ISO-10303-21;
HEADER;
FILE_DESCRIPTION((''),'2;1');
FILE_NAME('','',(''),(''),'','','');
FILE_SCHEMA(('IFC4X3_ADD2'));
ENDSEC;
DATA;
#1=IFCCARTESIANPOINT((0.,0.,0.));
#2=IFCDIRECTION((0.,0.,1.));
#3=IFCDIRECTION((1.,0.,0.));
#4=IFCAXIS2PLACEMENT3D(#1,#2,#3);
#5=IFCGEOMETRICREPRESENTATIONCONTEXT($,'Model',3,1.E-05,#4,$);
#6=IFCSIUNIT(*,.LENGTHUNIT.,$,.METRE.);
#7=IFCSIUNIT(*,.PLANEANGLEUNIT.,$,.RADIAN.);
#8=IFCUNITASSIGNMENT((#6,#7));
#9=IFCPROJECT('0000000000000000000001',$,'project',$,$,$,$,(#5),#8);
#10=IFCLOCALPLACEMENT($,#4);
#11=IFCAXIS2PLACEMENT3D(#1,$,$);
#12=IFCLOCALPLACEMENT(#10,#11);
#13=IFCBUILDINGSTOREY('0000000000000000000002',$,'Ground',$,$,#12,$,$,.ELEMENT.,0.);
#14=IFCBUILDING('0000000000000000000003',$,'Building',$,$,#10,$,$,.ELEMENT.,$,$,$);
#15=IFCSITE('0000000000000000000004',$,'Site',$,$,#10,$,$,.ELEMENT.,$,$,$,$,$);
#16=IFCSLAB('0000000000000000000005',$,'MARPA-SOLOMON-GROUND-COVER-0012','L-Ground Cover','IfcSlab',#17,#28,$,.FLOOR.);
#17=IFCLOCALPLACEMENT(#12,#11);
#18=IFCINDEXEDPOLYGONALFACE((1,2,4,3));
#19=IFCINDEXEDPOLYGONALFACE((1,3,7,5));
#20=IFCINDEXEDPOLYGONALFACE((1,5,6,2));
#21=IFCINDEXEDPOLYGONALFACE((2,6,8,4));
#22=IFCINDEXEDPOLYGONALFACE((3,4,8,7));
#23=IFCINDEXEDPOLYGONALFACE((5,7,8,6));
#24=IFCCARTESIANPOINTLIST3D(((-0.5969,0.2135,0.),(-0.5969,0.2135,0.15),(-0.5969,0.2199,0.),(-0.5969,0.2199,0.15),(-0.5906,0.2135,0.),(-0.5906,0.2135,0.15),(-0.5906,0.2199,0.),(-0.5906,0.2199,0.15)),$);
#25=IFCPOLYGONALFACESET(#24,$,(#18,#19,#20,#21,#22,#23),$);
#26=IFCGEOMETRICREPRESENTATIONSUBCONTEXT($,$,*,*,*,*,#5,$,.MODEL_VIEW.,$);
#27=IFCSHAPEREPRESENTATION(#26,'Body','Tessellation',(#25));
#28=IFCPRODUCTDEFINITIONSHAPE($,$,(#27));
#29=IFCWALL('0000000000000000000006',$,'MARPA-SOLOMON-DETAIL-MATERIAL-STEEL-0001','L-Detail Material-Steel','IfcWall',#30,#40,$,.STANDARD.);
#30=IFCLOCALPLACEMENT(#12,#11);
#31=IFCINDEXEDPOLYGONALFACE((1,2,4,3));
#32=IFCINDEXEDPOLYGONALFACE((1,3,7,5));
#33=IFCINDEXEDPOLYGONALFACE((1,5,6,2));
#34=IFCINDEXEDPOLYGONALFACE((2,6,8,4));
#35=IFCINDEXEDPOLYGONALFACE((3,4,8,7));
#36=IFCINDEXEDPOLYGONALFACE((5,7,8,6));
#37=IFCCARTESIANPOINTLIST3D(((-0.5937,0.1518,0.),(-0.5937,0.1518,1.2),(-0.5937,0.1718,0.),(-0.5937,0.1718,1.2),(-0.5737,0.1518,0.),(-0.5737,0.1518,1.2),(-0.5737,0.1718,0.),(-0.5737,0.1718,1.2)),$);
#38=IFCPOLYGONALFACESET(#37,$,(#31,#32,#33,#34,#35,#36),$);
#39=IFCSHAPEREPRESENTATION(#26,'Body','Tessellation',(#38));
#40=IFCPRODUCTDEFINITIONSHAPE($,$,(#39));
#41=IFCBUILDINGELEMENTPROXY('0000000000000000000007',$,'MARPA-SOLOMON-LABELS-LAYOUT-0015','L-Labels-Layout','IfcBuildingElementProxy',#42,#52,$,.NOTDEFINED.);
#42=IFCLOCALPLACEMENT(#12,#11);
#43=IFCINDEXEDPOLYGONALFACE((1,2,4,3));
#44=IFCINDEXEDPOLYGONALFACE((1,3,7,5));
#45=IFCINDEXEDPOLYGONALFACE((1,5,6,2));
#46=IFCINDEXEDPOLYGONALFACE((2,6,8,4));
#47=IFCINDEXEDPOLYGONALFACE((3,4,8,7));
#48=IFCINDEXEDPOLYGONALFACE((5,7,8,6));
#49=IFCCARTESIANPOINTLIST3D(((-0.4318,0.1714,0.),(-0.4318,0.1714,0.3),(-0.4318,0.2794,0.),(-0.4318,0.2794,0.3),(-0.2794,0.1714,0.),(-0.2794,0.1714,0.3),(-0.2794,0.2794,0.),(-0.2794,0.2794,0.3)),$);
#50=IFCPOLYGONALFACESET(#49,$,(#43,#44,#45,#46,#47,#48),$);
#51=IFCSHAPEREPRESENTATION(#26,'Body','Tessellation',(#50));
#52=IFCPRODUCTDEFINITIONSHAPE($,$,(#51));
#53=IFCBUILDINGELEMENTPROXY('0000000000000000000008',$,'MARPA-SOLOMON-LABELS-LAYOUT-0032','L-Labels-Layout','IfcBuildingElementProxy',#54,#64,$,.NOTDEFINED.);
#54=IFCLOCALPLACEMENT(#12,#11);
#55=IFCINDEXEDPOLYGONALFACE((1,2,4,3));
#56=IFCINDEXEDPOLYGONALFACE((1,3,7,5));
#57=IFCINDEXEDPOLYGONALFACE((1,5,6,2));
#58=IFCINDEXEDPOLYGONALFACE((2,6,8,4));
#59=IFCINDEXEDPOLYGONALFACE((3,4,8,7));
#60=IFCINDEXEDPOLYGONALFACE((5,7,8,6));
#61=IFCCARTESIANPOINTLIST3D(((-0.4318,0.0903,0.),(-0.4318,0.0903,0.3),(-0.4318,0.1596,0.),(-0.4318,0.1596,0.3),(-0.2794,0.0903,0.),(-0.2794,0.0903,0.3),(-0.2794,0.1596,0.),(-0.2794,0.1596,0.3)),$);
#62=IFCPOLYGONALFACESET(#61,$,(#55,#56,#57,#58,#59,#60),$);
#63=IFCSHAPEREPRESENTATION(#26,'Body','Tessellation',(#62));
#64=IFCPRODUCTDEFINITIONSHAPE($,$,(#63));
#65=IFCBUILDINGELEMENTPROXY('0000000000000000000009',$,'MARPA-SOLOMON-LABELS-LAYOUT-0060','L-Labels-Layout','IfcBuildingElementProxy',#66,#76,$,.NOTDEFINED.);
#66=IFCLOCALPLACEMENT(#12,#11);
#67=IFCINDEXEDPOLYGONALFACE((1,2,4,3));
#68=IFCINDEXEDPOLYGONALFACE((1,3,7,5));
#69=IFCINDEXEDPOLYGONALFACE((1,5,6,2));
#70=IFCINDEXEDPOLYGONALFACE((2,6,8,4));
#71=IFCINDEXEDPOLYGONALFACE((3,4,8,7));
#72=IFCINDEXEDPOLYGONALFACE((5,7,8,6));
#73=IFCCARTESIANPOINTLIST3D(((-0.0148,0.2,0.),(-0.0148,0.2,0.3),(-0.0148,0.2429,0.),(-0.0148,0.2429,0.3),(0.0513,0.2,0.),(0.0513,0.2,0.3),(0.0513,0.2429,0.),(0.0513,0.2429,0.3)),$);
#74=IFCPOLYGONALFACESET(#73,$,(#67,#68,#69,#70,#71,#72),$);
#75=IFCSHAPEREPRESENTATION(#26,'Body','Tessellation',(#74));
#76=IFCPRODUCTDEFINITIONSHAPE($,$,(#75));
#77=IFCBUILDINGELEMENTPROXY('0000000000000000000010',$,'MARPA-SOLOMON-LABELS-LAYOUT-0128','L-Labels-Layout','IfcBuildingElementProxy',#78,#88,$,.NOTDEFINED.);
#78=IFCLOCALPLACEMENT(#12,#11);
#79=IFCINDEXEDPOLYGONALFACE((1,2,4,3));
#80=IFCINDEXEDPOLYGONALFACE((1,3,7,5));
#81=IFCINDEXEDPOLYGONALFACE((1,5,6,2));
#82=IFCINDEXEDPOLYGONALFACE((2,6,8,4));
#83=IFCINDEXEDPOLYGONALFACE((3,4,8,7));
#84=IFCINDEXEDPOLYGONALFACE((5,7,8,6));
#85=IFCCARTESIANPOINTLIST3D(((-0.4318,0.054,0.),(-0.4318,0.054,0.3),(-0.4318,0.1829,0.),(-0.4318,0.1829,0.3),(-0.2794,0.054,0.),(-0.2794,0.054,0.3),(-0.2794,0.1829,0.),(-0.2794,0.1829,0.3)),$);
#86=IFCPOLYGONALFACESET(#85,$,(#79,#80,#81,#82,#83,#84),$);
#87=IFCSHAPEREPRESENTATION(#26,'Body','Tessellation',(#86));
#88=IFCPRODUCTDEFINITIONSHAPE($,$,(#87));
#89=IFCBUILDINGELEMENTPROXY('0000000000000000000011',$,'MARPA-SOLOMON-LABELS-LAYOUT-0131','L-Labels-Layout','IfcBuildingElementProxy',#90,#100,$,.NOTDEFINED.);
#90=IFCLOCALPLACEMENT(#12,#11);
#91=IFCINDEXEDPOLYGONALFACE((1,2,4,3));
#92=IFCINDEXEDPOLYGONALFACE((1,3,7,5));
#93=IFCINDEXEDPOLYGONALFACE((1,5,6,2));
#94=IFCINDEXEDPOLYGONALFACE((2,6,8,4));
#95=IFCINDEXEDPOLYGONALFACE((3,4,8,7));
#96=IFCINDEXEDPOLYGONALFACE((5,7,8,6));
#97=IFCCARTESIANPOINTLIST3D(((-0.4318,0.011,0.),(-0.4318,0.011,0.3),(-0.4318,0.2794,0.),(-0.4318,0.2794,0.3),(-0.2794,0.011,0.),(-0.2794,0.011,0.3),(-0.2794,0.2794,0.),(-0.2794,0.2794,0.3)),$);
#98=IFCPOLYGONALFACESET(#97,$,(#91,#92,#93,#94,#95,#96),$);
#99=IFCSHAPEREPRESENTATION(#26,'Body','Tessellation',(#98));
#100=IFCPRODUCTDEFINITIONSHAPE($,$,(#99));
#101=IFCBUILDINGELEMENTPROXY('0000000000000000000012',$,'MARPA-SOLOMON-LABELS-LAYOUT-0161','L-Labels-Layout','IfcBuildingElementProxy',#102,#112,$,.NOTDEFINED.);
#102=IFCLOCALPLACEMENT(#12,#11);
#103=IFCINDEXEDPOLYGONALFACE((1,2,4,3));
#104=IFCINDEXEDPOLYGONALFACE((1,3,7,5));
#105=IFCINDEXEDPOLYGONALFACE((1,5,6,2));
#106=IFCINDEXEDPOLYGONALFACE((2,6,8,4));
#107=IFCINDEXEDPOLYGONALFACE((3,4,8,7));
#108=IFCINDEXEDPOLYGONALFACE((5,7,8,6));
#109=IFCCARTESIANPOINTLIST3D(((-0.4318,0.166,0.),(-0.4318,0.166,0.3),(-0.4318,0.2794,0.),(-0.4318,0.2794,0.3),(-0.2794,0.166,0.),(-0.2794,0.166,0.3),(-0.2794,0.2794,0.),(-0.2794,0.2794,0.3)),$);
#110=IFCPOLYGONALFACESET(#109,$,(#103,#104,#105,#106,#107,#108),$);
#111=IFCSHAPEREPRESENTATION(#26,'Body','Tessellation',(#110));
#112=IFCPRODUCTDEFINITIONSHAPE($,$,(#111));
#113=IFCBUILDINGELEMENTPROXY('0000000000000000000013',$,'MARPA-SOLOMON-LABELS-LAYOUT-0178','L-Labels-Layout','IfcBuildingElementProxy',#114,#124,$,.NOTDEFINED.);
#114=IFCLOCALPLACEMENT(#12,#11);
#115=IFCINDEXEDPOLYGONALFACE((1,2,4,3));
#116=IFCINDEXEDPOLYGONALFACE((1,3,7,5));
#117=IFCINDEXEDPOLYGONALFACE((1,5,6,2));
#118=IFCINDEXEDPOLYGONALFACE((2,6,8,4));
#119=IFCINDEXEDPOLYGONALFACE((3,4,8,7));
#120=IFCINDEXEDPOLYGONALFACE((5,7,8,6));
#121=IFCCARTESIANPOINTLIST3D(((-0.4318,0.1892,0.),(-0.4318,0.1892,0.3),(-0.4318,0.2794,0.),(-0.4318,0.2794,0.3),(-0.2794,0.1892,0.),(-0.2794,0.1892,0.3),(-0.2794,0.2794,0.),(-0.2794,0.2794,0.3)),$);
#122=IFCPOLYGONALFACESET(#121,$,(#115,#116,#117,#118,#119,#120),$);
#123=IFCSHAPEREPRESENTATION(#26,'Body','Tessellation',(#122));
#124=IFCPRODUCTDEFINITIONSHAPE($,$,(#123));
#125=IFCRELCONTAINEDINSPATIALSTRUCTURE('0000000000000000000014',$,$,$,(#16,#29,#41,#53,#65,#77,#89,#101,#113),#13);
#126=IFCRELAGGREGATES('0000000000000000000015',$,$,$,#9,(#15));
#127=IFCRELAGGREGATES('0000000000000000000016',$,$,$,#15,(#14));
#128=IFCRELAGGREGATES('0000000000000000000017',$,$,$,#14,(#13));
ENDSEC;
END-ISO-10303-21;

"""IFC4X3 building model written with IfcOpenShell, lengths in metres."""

from ifc_helpers import new_model, si_unit, frame, frame_2d, origin, origin_with_axes, place, context, subcontext, project, spatial, polyline, rectangle, outline, extrude, element, save


model = new_model("IFC4X3")

# Units and contexts
model_context = context("Model", 3, precision=1e-05, world=origin_with_axes())
sub_context = subcontext(model_context, None, None, "MODEL_VIEW")
ifc_project = project(units=[si_unit("LENGTHUNIT", "METRE"), si_unit("PLANEANGLEUNIT", "RADIAN")], contexts=[model_context])

# Site, building, storey
placement = place(None, origin_with_axes())
site = spatial("IfcSite", under=ifc_project, at=placement, Name="Site", CompositionType="ELEMENT")
building = spatial("IfcBuilding", under=site, at=placement, Name="Building", CompositionType="ELEMENT")
storey_placement = place(placement, origin())
storey = spatial("IfcBuildingStorey", under=building, at=storey_placement, Name="Ground", CompositionType="ELEMENT", Elevation=0.0)

# Slab
for number, where, name in (
    (1, (-0.5969, 0.2135, 0.0), "MARPA-SOLOMON-GROUND-COVER-0012"),
):
    element("IfcSlab", number, at=place(storey_placement, frame(where)), inside=storey, Name=name, Description="L-Ground Cover", ObjectType="IfcSlab", PredefinedType="FLOOR", context=sub_context, shape_type="SweptSolid", body=[
        extrude(outline(polyline([(0.0, 0.0063), (0.0063, 0.0063), (0.0063, 0.0), (0.0, 0.0), (0.0, 0.0063)])), origin(), (0.0, 0.0, 1.0), 0.15),
    ])

# Wall
for number, where, x_axis, name in (
    (2, (-0.5937, 0.1618, 0.0), (1.0, 0.0, 0.0), "MARPA-SOLOMON-DETAIL-MATERIAL-STEEL-0001"),
):
    element("IfcWall", number, at=place(storey_placement, frame(where, x_axis=x_axis)), inside=storey, Name=name, Description="L-Detail Material-Steel", ObjectType="IfcWall", PredefinedType="STANDARD", context=sub_context, shape_type="SweptSolid", body=[
        extrude(rectangle(XDim=0.02, YDim=0.02, at=frame_2d((0.01, 0.0))), origin(), (0.0, 0.0, 1.0), 1.2),
    ])

# Building element proxies
for number, where, name in (
    (3, (-0.4318, 0.1714, 0.0), "MARPA-SOLOMON-LABELS-LAYOUT-0015"),
):
    element("IfcBuildingElementProxy", number, at=place(placement, frame(where)), inside=storey, Name=name, Description="L-Labels-Layout", ObjectType="IfcBuildingElementProxy", PredefinedType="NOTDEFINED", context=sub_context, shape_type="SweptSolid", body=[
        extrude(outline(polyline([(0.0, 0.1079), (0.1524, 0.1079), (0.1524, 0.0), (0.0, 0.0), (0.0, 0.1079)])), origin(), (0.0, 0.0, 1.0), 0.3),
    ])
proxy_1_placement = place(placement, frame((-0.4318, 0.0903, 0.0)))
element("IfcBuildingElementProxy", 4, at=proxy_1_placement, inside=storey, Name="MARPA-SOLOMON-LABELS-LAYOUT-0032", Description="L-Labels-Layout", ObjectType="IfcBuildingElementProxy", PredefinedType="NOTDEFINED", context=sub_context, shape_type="SweptSolid", body=[
    extrude(outline(polyline([(0.0, 0.0693), (0.1524, 0.0693), (0.1524, 0.0), (0.0, 0.0), (0.0, 0.0693)])), origin(), (0.0, 0.0, 1.0), 0.3),
])
proxy_2_placement = place(placement, frame((-0.0148, 0.2, 0.0)))
element("IfcBuildingElementProxy", 5, at=proxy_2_placement, inside=storey, Name="MARPA-SOLOMON-LABELS-LAYOUT-0060", Description="L-Labels-Layout", ObjectType="IfcBuildingElementProxy", PredefinedType="NOTDEFINED", context=sub_context, shape_type="SweptSolid", body=[
    extrude(outline(polyline([(0.0, 0.043), (0.066, 0.043), (0.066, 0.0), (0.0, 0.0), (0.0, 0.043)])), origin(), (0.0, 0.0, 1.0), 0.3),
])
proxy_3_placement = place(placement, frame((-0.4318, 0.054, 0.0)))
element("IfcBuildingElementProxy", 6, at=proxy_3_placement, inside=storey, Name="MARPA-SOLOMON-LABELS-LAYOUT-0128", Description="L-Labels-Layout", ObjectType="IfcBuildingElementProxy", PredefinedType="NOTDEFINED", context=sub_context, shape_type="SweptSolid", body=[
    extrude(outline(polyline([(0.0, 0.1289), (0.1524, 0.1289), (0.1524, 0.0), (0.0, 0.0), (0.0, 0.1289)])), origin(), (0.0, 0.0, 1.0), 0.3),
])
proxy_4_placement = place(placement, frame((-0.4318, 0.011, 0.0)))
element("IfcBuildingElementProxy", 7, at=proxy_4_placement, inside=storey, Name="MARPA-SOLOMON-LABELS-LAYOUT-0131", Description="L-Labels-Layout", ObjectType="IfcBuildingElementProxy", PredefinedType="NOTDEFINED", context=sub_context, shape_type="SweptSolid", body=[
    extrude(outline(polyline([(0.0, 0.2684), (0.1524, 0.2684), (0.1524, 0.0), (0.0, 0.0), (0.0, 0.2684)])), origin(), (0.0, 0.0, 1.0), 0.3),
])
proxy_5_placement = place(placement, frame((-0.4318, 0.166, 0.0)))
element("IfcBuildingElementProxy", 8, at=proxy_5_placement, inside=storey, Name="MARPA-SOLOMON-LABELS-LAYOUT-0161", Description="L-Labels-Layout", ObjectType="IfcBuildingElementProxy", PredefinedType="NOTDEFINED", context=sub_context, shape_type="SweptSolid", body=[
    extrude(outline(polyline([(0.0, 0.1134), (0.1524, 0.1134), (0.1524, 0.0), (0.0, 0.0), (0.0, 0.1134)])), origin(), (0.0, 0.0, 1.0), 0.3),
])
proxy_6_placement = place(placement, frame((-0.4318, 0.1892, 0.0)))
element("IfcBuildingElementProxy", 9, at=proxy_6_placement, inside=storey, Name="MARPA-SOLOMON-LABELS-LAYOUT-0178", Description="L-Labels-Layout", ObjectType="IfcBuildingElementProxy", PredefinedType="NOTDEFINED", context=sub_context, shape_type="SweptSolid", body=[
    extrude(outline(polyline([(0.0, 0.0902), (0.1524, 0.0902), (0.1524, 0.0), (0.0, 0.0), (0.0, 0.0902)])), origin(), (0.0, 0.0, 1.0), 0.3),
])

save(model, "model.ifc")
